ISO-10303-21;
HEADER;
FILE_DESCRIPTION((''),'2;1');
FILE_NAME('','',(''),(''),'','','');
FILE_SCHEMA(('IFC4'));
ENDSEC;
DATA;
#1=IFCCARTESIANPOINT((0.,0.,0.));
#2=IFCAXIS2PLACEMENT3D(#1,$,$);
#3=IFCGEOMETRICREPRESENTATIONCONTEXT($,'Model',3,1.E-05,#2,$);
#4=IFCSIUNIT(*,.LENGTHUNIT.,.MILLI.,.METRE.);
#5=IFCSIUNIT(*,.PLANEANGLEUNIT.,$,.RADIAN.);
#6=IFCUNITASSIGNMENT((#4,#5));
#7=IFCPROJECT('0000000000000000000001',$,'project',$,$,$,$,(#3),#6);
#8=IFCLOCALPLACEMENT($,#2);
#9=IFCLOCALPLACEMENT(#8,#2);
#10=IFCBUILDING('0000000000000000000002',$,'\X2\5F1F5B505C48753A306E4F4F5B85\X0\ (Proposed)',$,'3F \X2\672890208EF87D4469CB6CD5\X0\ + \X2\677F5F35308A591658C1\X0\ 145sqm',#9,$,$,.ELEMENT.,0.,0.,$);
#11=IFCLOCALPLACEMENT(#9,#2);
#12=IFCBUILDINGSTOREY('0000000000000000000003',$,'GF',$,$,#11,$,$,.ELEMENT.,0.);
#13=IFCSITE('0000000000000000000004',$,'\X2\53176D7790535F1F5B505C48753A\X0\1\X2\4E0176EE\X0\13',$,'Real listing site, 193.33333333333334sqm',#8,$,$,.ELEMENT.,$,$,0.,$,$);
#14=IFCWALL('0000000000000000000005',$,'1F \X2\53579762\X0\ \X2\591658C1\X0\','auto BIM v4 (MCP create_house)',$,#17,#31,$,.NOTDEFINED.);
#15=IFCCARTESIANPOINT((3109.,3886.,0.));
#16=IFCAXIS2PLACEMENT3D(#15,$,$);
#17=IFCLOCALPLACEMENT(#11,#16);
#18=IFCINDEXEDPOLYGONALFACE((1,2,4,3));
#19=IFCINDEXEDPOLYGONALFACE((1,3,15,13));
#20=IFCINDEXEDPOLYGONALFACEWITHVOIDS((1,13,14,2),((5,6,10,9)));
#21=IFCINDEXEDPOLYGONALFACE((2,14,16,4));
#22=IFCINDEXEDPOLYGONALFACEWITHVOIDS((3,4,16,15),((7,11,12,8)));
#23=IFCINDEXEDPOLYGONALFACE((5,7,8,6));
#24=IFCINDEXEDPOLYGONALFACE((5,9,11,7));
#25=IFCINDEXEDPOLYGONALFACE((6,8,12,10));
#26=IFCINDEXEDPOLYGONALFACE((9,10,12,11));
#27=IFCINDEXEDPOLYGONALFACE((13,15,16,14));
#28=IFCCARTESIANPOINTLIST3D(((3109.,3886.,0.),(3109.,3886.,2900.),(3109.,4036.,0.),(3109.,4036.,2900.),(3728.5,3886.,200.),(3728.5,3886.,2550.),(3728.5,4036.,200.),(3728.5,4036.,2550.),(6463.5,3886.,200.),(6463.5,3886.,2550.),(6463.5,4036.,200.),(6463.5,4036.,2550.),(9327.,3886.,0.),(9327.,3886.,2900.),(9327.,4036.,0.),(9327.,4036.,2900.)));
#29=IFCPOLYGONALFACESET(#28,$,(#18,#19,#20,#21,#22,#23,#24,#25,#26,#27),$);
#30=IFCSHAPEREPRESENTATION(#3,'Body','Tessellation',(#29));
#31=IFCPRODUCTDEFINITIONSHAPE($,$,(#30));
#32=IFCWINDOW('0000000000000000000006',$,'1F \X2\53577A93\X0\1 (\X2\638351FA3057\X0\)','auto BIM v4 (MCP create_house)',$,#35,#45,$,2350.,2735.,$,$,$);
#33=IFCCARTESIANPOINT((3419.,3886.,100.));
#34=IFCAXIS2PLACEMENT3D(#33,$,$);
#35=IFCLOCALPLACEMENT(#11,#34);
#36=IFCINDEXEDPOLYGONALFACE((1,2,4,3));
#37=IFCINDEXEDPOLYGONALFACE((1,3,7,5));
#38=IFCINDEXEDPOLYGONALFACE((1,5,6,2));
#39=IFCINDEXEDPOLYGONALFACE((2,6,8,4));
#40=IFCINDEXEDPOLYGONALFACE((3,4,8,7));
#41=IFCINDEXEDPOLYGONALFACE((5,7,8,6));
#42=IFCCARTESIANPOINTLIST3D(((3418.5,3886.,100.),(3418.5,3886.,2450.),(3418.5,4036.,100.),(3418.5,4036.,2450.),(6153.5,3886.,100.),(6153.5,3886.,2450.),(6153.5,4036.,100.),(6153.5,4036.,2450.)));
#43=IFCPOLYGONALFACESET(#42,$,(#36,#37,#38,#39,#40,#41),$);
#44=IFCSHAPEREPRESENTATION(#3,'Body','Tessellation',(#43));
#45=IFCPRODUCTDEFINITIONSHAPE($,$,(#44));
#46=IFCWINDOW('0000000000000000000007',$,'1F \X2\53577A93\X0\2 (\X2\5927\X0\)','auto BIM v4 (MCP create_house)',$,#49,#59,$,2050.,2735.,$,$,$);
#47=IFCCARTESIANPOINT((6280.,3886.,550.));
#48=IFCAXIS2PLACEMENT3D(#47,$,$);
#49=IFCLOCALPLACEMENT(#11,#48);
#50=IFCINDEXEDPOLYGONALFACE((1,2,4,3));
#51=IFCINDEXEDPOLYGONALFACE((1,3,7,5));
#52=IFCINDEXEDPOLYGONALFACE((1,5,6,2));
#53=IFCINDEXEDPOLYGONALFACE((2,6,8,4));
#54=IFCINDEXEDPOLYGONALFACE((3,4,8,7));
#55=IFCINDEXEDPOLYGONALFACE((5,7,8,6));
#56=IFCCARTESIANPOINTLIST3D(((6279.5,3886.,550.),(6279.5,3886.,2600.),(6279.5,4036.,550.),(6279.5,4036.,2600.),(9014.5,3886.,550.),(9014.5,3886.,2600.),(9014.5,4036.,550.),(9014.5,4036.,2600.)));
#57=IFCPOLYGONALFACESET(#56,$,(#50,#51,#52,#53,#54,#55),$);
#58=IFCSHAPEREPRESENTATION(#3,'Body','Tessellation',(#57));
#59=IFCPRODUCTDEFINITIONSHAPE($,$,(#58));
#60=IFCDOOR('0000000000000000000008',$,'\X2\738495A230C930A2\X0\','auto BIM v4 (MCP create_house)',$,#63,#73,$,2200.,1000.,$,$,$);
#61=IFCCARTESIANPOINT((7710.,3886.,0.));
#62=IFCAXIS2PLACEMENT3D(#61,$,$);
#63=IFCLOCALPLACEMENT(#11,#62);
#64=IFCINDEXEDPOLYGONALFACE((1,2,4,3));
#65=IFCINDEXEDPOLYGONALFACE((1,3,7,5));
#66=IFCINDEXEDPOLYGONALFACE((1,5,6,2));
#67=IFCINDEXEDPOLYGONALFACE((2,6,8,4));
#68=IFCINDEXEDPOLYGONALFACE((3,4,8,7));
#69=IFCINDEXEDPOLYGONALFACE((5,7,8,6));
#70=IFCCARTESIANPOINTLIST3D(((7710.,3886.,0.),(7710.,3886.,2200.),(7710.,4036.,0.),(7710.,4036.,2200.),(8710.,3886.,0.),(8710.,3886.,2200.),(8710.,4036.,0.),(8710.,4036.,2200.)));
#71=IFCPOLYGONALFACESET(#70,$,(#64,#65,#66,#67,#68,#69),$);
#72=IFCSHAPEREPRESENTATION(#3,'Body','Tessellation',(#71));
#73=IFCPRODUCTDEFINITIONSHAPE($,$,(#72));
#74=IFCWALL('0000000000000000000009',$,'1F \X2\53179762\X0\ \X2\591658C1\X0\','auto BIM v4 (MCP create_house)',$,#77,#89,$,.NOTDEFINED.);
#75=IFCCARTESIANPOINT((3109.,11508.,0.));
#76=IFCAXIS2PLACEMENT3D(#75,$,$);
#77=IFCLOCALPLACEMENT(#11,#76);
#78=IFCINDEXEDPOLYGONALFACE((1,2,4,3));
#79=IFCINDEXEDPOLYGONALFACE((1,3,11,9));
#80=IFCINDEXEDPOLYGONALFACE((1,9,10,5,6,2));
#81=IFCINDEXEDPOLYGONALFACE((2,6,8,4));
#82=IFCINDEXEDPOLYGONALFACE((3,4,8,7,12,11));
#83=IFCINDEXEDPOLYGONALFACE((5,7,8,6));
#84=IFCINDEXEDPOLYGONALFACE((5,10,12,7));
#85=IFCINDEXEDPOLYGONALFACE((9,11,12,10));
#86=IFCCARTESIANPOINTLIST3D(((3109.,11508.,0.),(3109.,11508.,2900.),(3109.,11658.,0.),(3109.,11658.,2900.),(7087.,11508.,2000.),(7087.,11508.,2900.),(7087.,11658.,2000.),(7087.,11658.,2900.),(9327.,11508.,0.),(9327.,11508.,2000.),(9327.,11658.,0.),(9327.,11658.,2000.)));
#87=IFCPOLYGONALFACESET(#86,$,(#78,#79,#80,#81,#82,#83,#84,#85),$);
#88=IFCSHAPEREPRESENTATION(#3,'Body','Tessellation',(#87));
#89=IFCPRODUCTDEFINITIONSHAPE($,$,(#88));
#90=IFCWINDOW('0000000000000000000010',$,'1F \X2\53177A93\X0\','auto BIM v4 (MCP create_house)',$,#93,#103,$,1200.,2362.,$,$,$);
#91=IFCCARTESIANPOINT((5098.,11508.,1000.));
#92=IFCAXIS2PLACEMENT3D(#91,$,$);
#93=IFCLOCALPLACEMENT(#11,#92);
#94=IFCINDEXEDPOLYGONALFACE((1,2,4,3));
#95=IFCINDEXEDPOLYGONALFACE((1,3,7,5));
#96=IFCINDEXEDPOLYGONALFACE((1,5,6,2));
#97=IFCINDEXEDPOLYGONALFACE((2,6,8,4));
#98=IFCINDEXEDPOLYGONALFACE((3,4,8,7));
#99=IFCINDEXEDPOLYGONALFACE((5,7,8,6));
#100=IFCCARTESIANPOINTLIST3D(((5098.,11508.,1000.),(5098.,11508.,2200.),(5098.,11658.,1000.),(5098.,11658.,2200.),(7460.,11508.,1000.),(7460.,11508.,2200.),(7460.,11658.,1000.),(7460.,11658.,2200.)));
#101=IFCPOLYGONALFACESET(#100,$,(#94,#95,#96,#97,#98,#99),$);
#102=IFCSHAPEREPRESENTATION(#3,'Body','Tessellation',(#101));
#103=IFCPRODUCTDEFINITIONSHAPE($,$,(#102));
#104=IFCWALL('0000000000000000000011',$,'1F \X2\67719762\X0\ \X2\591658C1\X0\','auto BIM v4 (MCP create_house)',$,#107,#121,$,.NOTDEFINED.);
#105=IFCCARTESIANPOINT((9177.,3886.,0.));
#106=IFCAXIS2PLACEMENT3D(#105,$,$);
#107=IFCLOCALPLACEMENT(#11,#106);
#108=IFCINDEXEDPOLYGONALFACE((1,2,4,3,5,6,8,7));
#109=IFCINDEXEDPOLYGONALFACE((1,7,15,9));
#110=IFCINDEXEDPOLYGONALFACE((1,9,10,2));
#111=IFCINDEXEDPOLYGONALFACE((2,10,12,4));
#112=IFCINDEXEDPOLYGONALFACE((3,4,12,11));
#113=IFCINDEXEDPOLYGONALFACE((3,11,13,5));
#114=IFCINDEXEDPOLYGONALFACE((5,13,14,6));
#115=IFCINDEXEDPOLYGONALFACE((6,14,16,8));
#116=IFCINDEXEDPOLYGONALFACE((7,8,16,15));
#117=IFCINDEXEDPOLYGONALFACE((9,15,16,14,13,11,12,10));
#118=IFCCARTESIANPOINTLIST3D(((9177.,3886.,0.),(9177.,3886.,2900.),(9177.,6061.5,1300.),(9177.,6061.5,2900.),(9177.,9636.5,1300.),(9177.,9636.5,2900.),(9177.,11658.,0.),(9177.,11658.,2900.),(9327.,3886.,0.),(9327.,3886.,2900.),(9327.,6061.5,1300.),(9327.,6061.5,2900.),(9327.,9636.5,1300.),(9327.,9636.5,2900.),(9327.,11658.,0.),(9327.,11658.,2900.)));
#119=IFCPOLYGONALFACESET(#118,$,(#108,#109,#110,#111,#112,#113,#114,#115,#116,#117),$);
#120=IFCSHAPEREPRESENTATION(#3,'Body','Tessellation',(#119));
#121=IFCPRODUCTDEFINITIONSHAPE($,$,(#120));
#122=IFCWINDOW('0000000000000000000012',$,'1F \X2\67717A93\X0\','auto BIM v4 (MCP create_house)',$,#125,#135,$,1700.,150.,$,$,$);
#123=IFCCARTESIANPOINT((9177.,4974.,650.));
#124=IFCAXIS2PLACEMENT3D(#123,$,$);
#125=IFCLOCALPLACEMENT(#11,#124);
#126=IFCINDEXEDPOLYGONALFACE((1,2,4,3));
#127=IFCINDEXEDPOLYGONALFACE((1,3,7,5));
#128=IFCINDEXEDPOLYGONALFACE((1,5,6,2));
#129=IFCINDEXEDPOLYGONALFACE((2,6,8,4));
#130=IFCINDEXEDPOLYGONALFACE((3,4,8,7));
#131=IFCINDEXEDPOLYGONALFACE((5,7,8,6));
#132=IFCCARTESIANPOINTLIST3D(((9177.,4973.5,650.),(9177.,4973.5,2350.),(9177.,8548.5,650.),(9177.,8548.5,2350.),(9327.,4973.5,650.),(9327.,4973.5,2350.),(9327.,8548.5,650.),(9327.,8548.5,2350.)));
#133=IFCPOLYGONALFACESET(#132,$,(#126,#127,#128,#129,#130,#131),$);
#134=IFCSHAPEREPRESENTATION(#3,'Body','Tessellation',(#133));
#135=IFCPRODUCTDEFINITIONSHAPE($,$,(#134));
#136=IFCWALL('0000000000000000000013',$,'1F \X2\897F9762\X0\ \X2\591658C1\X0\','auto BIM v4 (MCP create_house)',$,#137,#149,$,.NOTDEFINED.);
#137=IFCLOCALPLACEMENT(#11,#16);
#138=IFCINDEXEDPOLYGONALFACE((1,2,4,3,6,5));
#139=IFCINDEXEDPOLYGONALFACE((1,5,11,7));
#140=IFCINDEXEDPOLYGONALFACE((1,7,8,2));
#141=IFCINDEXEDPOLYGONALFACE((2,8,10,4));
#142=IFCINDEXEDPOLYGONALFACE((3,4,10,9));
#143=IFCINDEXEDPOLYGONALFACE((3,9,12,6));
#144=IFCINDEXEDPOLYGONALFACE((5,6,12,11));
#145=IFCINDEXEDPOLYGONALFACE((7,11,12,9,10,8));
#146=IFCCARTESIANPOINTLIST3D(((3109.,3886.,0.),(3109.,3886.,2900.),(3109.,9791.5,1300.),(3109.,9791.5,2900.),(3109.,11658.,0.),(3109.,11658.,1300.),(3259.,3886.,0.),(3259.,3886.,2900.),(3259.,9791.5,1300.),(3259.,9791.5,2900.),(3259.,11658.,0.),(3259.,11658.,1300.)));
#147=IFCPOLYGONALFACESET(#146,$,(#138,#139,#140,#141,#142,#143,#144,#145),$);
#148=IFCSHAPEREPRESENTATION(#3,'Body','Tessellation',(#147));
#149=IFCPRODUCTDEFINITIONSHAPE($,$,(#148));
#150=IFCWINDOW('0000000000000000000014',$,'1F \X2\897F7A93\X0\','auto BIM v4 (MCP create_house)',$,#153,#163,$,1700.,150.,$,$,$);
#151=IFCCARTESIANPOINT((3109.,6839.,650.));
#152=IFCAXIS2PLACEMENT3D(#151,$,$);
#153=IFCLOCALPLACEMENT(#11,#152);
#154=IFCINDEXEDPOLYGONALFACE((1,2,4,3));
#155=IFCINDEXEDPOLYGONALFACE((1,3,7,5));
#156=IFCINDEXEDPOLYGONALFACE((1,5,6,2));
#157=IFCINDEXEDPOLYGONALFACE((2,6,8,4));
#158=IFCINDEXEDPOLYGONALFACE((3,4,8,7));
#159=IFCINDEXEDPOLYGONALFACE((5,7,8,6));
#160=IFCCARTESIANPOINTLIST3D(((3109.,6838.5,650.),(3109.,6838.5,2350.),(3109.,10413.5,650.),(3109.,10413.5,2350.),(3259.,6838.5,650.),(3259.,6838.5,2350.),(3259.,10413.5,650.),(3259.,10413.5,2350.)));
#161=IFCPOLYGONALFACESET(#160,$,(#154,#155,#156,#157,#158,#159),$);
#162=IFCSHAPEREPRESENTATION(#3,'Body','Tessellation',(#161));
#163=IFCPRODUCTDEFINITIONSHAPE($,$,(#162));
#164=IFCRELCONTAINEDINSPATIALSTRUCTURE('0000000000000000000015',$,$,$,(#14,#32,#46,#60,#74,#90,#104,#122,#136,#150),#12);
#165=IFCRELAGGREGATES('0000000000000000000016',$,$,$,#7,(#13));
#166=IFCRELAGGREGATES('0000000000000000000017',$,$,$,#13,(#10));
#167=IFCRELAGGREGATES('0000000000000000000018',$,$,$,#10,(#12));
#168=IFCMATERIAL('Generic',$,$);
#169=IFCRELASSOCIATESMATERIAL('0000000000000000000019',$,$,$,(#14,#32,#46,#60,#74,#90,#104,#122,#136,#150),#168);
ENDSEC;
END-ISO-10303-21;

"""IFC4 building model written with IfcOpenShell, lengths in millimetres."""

from ifc_helpers import new_model, si_unit, frame, frame_2d, origin, place, context, project, spatial, rectangle, extrude, material, element, fill, save


model = new_model("IFC4")

# Units and contexts
model_context = context("Model", 3, precision=1e-05, world=origin())
ifc_project = project(units=[si_unit("LENGTHUNIT", "METRE", prefix="MILLI"), si_unit("PLANEANGLEUNIT", "RADIAN")], contexts=[model_context])

# Site, building, storey
site_placement = place(None, origin())
site = spatial("IfcSite", under=ifc_project, at=site_placement, Name="北海道弟子屈町1丁目13", ObjectType="Real listing site, 193.33333333333334sqm", CompositionType="ELEMENT", RefElevation=0.0)
building_placement = place(site_placement, origin())
building = spatial("IfcBuilding", under=site, at=building_placement, Name="弟子屈町の住宅 (Proposed)", ObjectType="3F 木造軸組構法 + 板張り外壁 145sqm", CompositionType="ELEMENT", ElevationOfRefHeight=0.0, ElevationOfTerrain=0.0)
storey_placement = place(building_placement, origin())
storey = spatial("IfcBuildingStorey", under=building, at=storey_placement, Name="GF", CompositionType="ELEMENT", Elevation=0.0)

# Shared definitions
ifc_material = material(Name="Generic")

# Wall, openings, windows, door
wall_1_placement = place(storey_placement, frame((3109.0, 3886.0, 0.0)))
wall_1 = element("IfcWall", 1, at=wall_1_placement, inside=storey, material=ifc_material, Name="1F 南面 外壁", Description="auto BIM v4 (MCP create_house)", PredefinedType="NOTDEFINED", context=model_context, shape_type="SweptSolid", body=[
    extrude(rectangle(XDim=6218.0, YDim=150.0, at=frame_2d((3109.0, 75.0))), frame((3109.0, 3886.0, 0.0)), (0.0, 0.0, 1.0), 2900.0),
])
opening_1_placement = place(storey_placement, frame((3419.0, 3886.0, 100.0)))
opening_1 = element("IfcOpeningElement", 2, at=opening_1_placement, cuts=wall_1, PredefinedType="NOTDEFINED", context=model_context, shape_type="SweptSolid", body=[
    extrude(rectangle(XDim=2735.0, YDim=150.0, at=frame_2d((1367.0, 75.0))), frame((3419.0, 3886.0, 100.0)), (0.0, 0.0, 1.0), 2350.0),
])
opening_2_placement = place(storey_placement, frame((6280.0, 3886.0, 550.0)))
opening_2 = element("IfcOpeningElement", 3, at=opening_2_placement, cuts=wall_1, PredefinedType="NOTDEFINED", context=model_context, shape_type="SweptSolid", body=[
    extrude(rectangle(XDim=2735.0, YDim=150.0, at=frame_2d((1367.0, 75.0))), frame((6280.0, 3886.0, 550.0)), (0.0, 0.0, 1.0), 2050.0),
])
opening_3_placement = place(storey_placement, frame((7710.0, 3886.0, 0.0)))
opening_3 = element("IfcOpeningElement", 4, at=opening_3_placement, cuts=wall_1, PredefinedType="NOTDEFINED", context=model_context, shape_type="SweptSolid", body=[
    extrude(rectangle(XDim=1000.0, YDim=150.0, at=frame_2d((500.0, 75.0))), frame((7710.0, 3886.0, 0.0)), (0.0, 0.0, 1.0), 2200.0),
])
window_1_placement = place(storey_placement, frame((3419.0, 3886.0, 100.0)))
window_1 = element("IfcWindow", 5, at=window_1_placement, inside=storey, material=ifc_material, Name="1F 南窓1 (掃出し)", Description="auto BIM v4 (MCP create_house)", OverallHeight=2350.0, OverallWidth=2735.0, context=model_context, shape_type="SweptSolid", body=[
    extrude(rectangle(XDim=2735.0, YDim=150.0, at=frame_2d((1367.0, 75.0))), frame((3419.0, 3886.0, 100.0)), (0.0, 0.0, 1.0), 2350.0),
])
fill(opening_1, window_1)
window_2_placement = place(storey_placement, frame((6280.0, 3886.0, 550.0)))
window_2 = element("IfcWindow", 6, at=window_2_placement, inside=storey, material=ifc_material, Name="1F 南窓2 (大)", Description="auto BIM v4 (MCP create_house)", OverallHeight=2050.0, OverallWidth=2735.0, context=model_context, shape_type="SweptSolid", body=[
    extrude(rectangle(XDim=2735.0, YDim=150.0, at=frame_2d((1367.0, 75.0))), frame((6280.0, 3886.0, 550.0)), (0.0, 0.0, 1.0), 2050.0),
])
fill(opening_2, window_2)
door_placement = place(storey_placement, frame((7710.0, 3886.0, 0.0)))
door = element("IfcDoor", 7, at=door_placement, inside=storey, material=ifc_material, Name="玄関ドア", Description="auto BIM v4 (MCP create_house)", OverallHeight=2200.0, OverallWidth=1000.0, context=model_context, shape_type="SweptSolid", body=[
    extrude(rectangle(XDim=1000.0, YDim=150.0, at=frame_2d((500.0, 75.0))), frame((7710.0, 3886.0, 0.0)), (0.0, 0.0, 1.0), 2200.0),
])
fill(opening_3, door)

# Walls, openings, windows
wall_2_placement = place(storey_placement, frame((3109.0, 11508.0, 0.0)))
wall_2 = element("IfcWall", 8, at=wall_2_placement, inside=storey, material=ifc_material, Name="1F 北面 外壁", Description="auto BIM v4 (MCP create_house)", PredefinedType="NOTDEFINED", context=model_context, shape_type="SweptSolid", body=[
    extrude(rectangle(XDim=6218.0, YDim=150.0, at=frame_2d((3109.0, 75.0))), frame((3109.0, 11508.0, 0.0)), (0.0, 0.0, 1.0), 2900.0),
])
opening_4_placement = place(storey_placement, frame((5098.0, 11508.0, 1000.0)))
opening_4 = element("IfcOpeningElement", 9, at=opening_4_placement, cuts=wall_2, PredefinedType="NOTDEFINED", context=model_context, shape_type="SweptSolid", body=[
    extrude(rectangle(XDim=2362.0, YDim=150.0, at=frame_2d((1181.0, 75.0))), frame((5098.0, 11508.0, 1000.0)), (0.0, 0.0, 1.0), 1200.0),
])
window_3_placement = place(storey_placement, frame((5098.0, 11508.0, 1000.0)))
window_3 = element("IfcWindow", 10, at=window_3_placement, inside=storey, material=ifc_material, Name="1F 北窓", Description="auto BIM v4 (MCP create_house)", OverallHeight=1200.0, OverallWidth=2362.0, context=model_context, shape_type="SweptSolid", body=[
    extrude(rectangle(XDim=2362.0, YDim=150.0, at=frame_2d((1181.0, 75.0))), frame((5098.0, 11508.0, 1000.0)), (0.0, 0.0, 1.0), 1200.0),
])
fill(opening_4, window_3)
wall_3_placement = place(storey_placement, frame((9177.0, 3886.0, 0.0)))
wall_3 = element("IfcWall", 11, at=wall_3_placement, inside=storey, material=ifc_material, Name="1F 東面 外壁", Description="auto BIM v4 (MCP create_house)", PredefinedType="NOTDEFINED", context=model_context, shape_type="SweptSolid", body=[
    extrude(rectangle(XDim=150.0, YDim=7772.0, at=frame_2d((75.0, 3886.0))), frame((9177.0, 3886.0, 0.0)), (0.0, 0.0, 1.0), 2900.0),
])
opening_5_placement = place(storey_placement, frame((9177.0, 4974.0, 650.0)))
opening_5 = element("IfcOpeningElement", 12, at=opening_5_placement, cuts=wall_3, PredefinedType="NOTDEFINED", context=model_context, shape_type="SweptSolid", body=[
    extrude(rectangle(XDim=150.0, YDim=3575.0, at=frame_2d((75.0, 1787.0))), frame((9177.0, 4974.0, 650.0)), (0.0, 0.0, 1.0), 1700.0),
])
window_4_placement = place(storey_placement, frame((9177.0, 4974.0, 650.0)))
window_4 = element("IfcWindow", 13, at=window_4_placement, inside=storey, material=ifc_material, Name="1F 東窓", Description="auto BIM v4 (MCP create_house)", OverallHeight=1700.0, OverallWidth=150.0, context=model_context, shape_type="SweptSolid", body=[
    extrude(rectangle(XDim=150.0, YDim=3575.0, at=frame_2d((75.0, 1787.0))), frame((9177.0, 4974.0, 650.0)), (0.0, 0.0, 1.0), 1700.0),
])
fill(opening_5, window_4)
wall_4_placement = place(storey_placement, frame((3109.0, 3886.0, 0.0)))
wall_4 = element("IfcWall", 14, at=wall_4_placement, inside=storey, material=ifc_material, Name="1F 西面 外壁", Description="auto BIM v4 (MCP create_house)", PredefinedType="NOTDEFINED", context=model_context, shape_type="SweptSolid", body=[
    extrude(rectangle(XDim=150.0, YDim=7772.0, at=frame_2d((75.0, 3886.0))), frame((3109.0, 3886.0, 0.0)), (0.0, 0.0, 1.0), 2900.0),
])
opening_6_placement = place(storey_placement, frame((3109.0, 6839.0, 650.0)))
opening_6 = element("IfcOpeningElement", 15, at=opening_6_placement, cuts=wall_4, PredefinedType="NOTDEFINED", context=model_context, shape_type="SweptSolid", body=[
    extrude(rectangle(XDim=150.0, YDim=3575.0, at=frame_2d((75.0, 1787.0))), frame((3109.0, 6839.0, 650.0)), (0.0, 0.0, 1.0), 1700.0),
])
window_5_placement = place(storey_placement, frame((3109.0, 6839.0, 650.0)))
window_5 = element("IfcWindow", 16, at=window_5_placement, inside=storey, material=ifc_material, Name="1F 西窓", Description="auto BIM v4 (MCP create_house)", OverallHeight=1700.0, OverallWidth=150.0, context=model_context, shape_type="SweptSolid", body=[
    extrude(rectangle(XDim=150.0, YDim=3575.0, at=frame_2d((75.0, 1787.0))), frame((3109.0, 6839.0, 650.0)), (0.0, 0.0, 1.0), 1700.0),
])
fill(opening_6, window_5)

save(model, "model.ifc")
